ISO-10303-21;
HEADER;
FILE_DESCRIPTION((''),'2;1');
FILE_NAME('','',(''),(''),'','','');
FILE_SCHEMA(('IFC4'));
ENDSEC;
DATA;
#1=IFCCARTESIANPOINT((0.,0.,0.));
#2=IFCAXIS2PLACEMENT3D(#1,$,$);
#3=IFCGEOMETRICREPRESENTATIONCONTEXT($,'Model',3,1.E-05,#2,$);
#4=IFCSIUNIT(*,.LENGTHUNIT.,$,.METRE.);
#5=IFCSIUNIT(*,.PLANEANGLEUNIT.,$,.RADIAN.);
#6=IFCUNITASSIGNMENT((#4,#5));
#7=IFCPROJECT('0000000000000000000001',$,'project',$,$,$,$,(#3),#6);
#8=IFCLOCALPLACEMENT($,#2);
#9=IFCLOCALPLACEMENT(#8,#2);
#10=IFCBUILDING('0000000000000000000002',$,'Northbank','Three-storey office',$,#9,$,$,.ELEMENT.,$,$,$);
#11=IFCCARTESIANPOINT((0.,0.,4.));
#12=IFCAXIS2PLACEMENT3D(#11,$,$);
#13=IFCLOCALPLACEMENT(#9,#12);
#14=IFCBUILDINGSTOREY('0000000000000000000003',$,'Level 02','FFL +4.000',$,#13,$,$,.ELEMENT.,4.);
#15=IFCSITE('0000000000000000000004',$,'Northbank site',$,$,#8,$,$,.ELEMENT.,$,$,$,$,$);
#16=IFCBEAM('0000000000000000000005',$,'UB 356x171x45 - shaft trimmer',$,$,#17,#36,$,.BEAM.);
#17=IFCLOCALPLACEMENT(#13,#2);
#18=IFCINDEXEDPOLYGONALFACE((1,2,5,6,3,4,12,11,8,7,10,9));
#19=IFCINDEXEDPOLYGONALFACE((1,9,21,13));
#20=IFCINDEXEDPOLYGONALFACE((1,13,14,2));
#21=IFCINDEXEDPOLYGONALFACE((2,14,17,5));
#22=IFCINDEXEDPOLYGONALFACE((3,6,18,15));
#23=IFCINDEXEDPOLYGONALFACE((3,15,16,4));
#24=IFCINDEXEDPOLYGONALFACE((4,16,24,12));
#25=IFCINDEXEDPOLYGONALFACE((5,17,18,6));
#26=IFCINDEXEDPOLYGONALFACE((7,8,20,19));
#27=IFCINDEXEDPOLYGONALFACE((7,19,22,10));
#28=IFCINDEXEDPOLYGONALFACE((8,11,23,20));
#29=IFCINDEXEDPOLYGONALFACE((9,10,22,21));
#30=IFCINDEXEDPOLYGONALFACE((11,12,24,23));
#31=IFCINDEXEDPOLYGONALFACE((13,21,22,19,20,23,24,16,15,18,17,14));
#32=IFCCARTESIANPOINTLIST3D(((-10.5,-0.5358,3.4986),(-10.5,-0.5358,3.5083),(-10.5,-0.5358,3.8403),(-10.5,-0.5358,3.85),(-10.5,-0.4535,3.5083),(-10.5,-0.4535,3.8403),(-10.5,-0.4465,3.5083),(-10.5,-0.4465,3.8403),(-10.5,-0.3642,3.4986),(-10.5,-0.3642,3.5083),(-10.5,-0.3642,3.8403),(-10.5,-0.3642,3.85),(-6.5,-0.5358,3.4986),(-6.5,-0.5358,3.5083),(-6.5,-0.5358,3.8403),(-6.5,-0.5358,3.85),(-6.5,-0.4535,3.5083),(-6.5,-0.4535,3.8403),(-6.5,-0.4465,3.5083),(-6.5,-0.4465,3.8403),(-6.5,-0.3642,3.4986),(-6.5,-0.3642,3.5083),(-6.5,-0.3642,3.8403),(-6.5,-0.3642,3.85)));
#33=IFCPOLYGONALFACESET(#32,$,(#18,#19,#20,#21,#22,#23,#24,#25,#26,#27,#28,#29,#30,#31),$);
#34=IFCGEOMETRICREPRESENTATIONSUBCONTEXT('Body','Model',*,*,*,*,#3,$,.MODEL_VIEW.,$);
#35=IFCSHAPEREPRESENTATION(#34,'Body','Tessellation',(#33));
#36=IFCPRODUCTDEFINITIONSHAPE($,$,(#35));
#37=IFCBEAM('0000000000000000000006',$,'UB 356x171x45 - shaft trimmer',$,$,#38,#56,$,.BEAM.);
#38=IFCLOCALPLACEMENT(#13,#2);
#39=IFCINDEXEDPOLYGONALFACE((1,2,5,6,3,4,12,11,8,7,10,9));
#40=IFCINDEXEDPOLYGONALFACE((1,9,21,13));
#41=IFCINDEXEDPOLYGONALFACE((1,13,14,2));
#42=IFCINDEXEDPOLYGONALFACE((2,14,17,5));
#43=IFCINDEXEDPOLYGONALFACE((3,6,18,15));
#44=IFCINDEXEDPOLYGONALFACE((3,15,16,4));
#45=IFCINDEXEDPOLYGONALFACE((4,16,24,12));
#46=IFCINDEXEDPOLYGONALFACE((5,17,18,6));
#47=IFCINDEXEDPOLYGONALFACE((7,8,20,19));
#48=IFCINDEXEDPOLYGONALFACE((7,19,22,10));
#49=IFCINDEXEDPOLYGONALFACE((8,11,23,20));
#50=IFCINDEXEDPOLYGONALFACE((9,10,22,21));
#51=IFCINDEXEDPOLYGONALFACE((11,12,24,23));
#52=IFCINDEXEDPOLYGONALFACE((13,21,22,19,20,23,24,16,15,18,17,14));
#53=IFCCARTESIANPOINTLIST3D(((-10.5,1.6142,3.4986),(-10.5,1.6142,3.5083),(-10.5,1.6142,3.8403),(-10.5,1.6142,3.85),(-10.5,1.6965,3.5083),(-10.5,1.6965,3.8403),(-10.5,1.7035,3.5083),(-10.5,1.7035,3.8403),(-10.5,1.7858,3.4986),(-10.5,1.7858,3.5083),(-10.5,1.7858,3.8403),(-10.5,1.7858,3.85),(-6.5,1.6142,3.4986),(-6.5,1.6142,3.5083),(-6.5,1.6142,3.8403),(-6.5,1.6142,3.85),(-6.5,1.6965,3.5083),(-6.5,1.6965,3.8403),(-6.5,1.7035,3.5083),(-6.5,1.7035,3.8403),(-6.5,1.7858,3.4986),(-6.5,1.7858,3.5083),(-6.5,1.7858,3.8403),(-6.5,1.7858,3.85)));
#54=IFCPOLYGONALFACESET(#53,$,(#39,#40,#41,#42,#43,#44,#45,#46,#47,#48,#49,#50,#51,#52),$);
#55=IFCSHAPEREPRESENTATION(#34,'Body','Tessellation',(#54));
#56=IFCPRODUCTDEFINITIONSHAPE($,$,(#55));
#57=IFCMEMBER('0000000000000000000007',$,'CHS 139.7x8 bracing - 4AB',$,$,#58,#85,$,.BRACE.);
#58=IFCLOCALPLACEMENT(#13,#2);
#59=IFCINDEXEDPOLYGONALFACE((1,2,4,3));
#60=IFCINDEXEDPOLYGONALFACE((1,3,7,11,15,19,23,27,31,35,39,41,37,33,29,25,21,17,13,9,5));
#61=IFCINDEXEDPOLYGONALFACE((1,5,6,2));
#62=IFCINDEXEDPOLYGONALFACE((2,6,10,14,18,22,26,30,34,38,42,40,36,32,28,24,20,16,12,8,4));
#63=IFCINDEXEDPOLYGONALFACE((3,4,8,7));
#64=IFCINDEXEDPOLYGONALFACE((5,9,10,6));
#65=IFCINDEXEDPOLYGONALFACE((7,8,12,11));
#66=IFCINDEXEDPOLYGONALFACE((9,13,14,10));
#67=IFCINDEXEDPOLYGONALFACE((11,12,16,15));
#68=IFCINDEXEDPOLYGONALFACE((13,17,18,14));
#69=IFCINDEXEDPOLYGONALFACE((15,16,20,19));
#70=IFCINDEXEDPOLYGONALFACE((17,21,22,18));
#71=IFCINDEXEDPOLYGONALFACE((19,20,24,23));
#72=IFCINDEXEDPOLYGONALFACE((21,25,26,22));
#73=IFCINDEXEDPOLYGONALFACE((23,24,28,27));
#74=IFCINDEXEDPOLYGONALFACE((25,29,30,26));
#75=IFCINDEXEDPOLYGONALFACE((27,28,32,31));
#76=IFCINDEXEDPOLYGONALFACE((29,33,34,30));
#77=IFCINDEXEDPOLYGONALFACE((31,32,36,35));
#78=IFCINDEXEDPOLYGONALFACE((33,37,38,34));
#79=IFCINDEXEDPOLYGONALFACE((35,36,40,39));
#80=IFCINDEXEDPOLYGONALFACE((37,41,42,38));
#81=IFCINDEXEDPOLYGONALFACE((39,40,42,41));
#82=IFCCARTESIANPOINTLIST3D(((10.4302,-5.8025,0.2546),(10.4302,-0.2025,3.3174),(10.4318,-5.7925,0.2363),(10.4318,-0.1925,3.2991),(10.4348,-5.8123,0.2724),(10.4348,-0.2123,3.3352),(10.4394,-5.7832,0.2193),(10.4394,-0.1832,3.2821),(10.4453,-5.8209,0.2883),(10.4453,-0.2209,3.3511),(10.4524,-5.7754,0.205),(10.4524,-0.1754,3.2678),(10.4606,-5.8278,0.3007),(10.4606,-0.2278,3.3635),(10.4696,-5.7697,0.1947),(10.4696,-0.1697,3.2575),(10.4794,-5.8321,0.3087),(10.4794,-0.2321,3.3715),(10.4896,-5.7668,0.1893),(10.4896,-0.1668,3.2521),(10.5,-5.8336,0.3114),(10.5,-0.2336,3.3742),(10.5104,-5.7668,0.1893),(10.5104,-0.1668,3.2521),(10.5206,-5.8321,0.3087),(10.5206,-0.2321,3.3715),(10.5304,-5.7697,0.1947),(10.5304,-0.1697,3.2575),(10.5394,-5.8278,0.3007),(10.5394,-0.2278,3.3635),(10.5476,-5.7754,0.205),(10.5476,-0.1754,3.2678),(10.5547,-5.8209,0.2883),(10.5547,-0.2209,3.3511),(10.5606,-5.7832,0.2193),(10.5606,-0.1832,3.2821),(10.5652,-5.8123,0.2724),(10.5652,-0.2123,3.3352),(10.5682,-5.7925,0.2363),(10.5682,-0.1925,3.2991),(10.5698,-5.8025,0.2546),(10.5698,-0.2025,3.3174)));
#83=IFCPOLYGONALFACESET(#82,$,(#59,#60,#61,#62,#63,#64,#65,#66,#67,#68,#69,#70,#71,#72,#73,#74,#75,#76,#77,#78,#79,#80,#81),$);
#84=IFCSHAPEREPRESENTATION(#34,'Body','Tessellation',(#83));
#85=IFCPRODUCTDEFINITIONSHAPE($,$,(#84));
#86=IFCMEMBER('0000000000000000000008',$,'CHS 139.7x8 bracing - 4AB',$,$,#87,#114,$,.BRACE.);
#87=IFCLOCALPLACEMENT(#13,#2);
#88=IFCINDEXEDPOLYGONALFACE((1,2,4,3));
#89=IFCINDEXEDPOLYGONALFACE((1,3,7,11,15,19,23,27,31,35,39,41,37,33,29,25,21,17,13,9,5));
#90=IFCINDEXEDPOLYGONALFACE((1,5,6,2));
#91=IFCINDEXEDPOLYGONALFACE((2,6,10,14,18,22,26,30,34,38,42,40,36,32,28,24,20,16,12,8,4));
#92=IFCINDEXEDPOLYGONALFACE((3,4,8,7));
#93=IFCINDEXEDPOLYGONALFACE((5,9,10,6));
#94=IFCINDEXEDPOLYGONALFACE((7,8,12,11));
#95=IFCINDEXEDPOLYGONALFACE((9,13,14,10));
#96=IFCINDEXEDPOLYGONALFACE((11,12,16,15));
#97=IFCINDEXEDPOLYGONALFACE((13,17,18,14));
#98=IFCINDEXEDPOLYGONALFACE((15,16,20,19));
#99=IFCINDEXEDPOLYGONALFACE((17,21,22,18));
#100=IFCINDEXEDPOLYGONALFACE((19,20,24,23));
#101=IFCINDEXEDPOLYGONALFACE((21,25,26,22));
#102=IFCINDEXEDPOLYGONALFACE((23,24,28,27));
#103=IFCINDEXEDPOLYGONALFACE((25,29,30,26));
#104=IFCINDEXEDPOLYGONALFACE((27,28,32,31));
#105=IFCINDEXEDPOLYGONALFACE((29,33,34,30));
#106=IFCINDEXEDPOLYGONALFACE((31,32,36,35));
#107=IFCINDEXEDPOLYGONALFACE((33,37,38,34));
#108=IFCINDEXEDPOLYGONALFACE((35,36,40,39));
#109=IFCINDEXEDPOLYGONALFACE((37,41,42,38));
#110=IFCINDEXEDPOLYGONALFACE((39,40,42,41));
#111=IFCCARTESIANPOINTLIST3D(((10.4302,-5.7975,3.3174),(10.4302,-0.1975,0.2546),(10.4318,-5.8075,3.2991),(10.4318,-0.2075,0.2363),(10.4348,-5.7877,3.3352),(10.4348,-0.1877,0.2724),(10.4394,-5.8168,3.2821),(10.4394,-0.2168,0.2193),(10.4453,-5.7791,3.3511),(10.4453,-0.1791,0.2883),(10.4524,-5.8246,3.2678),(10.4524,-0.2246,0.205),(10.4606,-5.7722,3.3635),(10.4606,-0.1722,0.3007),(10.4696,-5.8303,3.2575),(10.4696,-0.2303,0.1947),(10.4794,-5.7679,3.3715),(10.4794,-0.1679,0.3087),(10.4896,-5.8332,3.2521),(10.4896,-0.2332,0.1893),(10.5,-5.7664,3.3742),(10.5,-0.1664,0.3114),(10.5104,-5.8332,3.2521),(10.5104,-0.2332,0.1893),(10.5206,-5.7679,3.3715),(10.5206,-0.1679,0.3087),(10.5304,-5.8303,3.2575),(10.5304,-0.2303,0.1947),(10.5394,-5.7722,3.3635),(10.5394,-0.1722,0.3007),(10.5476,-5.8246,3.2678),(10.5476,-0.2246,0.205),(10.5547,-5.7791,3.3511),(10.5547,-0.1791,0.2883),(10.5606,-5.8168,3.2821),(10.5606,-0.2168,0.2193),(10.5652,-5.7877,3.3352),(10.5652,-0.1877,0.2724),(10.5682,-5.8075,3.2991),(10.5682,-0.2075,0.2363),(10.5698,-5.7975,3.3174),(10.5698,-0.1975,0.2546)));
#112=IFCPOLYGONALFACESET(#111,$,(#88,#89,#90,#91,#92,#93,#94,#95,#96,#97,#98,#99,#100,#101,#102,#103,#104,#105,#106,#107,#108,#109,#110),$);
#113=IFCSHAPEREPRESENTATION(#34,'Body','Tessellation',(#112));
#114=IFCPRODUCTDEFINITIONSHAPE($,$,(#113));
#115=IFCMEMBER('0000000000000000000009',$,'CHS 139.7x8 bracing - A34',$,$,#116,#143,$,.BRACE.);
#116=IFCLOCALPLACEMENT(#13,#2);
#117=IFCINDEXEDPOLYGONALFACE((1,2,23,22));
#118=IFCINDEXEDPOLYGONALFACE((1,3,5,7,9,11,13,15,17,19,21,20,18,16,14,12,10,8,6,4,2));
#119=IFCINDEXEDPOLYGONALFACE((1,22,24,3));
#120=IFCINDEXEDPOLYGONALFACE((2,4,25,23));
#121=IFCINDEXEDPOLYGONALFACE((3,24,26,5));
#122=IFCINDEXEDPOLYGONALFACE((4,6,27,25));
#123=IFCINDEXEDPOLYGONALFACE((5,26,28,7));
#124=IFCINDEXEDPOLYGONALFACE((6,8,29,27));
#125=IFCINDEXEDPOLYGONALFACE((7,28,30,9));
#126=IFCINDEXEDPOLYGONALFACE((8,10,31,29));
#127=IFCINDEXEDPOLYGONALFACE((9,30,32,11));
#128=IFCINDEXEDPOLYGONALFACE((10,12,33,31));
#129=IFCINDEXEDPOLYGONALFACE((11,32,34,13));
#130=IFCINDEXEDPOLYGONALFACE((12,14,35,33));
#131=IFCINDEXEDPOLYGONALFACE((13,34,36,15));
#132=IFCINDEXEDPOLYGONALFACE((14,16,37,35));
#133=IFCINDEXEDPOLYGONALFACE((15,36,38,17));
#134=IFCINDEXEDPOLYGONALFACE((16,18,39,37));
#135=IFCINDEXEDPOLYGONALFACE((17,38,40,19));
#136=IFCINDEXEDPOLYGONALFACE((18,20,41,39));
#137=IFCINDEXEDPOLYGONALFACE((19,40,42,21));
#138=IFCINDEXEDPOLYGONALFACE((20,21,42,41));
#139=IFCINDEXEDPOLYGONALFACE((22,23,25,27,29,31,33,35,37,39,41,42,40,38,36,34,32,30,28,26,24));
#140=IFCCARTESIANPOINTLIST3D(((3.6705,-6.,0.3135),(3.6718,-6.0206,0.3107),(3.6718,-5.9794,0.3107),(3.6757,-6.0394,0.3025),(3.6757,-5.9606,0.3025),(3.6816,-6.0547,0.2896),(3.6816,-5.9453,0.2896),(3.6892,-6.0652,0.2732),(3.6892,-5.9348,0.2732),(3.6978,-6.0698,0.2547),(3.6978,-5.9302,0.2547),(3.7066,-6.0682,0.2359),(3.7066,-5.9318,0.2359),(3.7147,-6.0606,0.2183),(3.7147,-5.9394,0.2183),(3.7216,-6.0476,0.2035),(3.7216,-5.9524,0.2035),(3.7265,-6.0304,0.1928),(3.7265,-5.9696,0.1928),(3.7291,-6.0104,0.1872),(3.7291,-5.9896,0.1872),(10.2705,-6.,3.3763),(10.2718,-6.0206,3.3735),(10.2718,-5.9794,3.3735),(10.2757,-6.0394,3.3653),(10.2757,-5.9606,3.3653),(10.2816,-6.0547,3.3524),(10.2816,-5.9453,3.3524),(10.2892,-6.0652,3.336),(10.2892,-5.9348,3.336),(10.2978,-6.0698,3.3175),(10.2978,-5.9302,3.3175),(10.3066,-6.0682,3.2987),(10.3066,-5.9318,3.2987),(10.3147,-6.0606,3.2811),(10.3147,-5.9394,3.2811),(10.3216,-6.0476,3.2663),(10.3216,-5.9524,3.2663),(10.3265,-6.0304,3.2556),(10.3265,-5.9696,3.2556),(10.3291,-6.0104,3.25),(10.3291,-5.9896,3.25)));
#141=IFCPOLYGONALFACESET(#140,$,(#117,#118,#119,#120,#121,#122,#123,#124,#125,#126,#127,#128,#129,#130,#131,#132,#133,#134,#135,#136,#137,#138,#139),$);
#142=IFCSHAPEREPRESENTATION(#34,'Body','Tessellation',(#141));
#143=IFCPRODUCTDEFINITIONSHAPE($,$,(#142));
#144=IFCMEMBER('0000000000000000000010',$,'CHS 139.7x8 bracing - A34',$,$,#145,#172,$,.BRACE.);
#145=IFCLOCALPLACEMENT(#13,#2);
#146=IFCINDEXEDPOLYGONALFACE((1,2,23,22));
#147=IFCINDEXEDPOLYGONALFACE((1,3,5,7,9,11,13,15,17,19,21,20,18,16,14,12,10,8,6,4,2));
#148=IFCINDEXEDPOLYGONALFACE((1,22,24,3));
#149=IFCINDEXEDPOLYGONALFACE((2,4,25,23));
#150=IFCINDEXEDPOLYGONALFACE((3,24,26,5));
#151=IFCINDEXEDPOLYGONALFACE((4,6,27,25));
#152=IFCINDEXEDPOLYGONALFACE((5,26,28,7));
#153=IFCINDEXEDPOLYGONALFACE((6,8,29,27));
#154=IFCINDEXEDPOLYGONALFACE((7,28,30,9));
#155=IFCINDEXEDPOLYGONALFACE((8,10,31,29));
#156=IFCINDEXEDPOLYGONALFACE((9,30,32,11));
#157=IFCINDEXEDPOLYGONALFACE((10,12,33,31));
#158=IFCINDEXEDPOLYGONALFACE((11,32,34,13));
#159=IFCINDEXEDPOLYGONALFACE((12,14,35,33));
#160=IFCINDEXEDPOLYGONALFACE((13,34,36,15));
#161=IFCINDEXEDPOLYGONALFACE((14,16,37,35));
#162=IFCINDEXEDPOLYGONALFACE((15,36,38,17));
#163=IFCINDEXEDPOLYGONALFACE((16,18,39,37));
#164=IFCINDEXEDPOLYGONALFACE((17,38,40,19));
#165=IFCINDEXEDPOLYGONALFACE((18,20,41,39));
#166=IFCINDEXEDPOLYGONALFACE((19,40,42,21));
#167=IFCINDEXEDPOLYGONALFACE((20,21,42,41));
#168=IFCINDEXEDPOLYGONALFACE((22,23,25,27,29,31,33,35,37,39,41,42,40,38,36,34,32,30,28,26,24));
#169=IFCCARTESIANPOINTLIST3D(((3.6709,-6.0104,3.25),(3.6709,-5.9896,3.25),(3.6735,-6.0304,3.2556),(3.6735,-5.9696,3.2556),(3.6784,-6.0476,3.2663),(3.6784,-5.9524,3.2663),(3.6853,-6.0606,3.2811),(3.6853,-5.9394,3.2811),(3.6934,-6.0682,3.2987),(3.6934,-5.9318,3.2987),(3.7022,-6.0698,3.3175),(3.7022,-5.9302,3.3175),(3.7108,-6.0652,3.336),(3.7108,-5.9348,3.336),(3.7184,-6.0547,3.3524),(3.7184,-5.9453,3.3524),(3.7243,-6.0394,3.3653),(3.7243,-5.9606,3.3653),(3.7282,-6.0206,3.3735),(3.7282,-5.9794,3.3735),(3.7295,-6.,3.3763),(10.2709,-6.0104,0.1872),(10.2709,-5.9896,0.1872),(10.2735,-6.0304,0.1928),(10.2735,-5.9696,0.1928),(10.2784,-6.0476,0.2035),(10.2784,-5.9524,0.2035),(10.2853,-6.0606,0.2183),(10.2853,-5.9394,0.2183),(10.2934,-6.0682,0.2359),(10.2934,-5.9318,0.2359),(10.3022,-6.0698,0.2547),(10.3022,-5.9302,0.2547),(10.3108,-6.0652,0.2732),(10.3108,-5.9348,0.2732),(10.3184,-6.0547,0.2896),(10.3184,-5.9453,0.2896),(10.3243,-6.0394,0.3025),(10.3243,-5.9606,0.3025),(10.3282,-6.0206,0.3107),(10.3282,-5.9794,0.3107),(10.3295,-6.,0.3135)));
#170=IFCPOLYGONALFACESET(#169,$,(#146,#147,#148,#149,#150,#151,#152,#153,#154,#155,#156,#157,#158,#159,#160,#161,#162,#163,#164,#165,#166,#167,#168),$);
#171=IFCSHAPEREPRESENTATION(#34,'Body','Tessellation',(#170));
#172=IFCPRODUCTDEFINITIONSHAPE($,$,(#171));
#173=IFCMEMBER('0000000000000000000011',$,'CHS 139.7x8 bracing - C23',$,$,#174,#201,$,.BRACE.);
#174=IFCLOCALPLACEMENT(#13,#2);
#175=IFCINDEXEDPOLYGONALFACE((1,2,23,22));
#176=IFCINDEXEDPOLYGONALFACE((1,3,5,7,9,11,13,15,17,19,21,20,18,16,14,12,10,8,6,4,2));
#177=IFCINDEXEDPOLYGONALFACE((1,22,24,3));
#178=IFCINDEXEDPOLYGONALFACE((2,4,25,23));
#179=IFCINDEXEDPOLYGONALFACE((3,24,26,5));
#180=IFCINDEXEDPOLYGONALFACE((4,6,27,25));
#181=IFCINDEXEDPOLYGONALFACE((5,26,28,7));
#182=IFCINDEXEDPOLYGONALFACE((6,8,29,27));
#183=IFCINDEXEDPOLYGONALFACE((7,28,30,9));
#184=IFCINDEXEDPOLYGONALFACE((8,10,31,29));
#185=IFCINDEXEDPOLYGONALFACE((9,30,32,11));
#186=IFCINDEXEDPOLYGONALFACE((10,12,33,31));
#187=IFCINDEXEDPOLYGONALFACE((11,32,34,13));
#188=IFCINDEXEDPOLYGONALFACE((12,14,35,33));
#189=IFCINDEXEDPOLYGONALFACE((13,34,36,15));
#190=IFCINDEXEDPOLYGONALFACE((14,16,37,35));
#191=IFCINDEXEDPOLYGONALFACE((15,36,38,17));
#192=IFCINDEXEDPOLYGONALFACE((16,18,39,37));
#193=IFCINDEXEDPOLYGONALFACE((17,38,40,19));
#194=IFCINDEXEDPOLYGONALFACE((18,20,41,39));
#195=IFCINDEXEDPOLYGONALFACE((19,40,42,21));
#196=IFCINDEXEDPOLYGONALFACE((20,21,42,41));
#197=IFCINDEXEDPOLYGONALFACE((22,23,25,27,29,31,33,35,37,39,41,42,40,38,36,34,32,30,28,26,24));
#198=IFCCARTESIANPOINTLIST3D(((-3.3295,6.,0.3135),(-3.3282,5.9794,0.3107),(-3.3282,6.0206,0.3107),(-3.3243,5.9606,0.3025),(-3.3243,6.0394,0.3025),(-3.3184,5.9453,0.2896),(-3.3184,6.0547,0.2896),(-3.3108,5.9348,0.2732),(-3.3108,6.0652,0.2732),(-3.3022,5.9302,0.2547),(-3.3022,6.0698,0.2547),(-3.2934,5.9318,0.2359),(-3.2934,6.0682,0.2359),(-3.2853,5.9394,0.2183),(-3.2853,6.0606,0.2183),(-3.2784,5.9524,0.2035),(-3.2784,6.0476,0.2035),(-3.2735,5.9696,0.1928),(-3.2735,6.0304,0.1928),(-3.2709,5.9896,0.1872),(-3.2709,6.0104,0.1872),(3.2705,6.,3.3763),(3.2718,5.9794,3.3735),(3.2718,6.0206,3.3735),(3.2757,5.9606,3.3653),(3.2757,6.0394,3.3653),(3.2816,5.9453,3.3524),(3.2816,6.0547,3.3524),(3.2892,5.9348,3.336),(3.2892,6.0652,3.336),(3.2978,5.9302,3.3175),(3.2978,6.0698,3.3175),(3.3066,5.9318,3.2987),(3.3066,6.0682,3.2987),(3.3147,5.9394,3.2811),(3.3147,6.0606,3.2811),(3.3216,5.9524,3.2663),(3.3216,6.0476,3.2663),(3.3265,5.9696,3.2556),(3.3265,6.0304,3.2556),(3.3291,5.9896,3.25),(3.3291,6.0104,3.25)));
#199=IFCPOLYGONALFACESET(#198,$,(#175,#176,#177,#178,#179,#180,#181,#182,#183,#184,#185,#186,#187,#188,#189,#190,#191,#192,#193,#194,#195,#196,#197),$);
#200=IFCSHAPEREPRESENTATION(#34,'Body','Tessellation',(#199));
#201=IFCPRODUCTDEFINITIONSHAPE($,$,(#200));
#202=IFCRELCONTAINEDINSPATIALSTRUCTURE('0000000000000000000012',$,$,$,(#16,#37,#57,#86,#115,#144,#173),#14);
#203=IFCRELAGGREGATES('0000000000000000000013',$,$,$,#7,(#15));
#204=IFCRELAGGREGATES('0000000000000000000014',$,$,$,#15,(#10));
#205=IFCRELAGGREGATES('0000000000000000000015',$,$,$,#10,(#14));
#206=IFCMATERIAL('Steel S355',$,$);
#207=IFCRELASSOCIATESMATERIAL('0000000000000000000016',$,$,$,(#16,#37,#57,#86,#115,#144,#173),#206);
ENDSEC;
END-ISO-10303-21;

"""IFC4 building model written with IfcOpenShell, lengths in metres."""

from ifc_helpers import new_model, si_unit, frame, origin, place, context, subcontext, project, spatial, circle, i_section, extrude, material, element, save


model = new_model("IFC4")

# Units and contexts
model_context = context("Model", 3, precision=1e-05, world=origin())
body_context = subcontext(model_context, "Body", "Model", "MODEL_VIEW")
ifc_project = project(units=[si_unit("LENGTHUNIT", "METRE"), si_unit("PLANEANGLEUNIT", "RADIAN")], contexts=[model_context])

# Site, building, storey
site_placement = place(None, origin())
site = spatial("IfcSite", under=ifc_project, at=site_placement, Name="Northbank site", CompositionType="ELEMENT")
building_placement = place(site_placement, origin())
building = spatial("IfcBuilding", under=site, at=building_placement, Name="Northbank", Description="Three-storey office", CompositionType="ELEMENT")
storey_placement = place(building_placement, frame((0.0, 0.0, 4.0)))
storey = spatial("IfcBuildingStorey", under=building, at=storey_placement, Name="Level 02", Description="FFL +4.000", CompositionType="ELEMENT", Elevation=4.0)

# Beams
ifc_material_1 = material(Name="Steel S355")
beam_1_placement = place(storey_placement, frame((0.0, 0.0, -4.0)))
element("IfcBeam", 1, at=beam_1_placement, inside=storey, material=ifc_material_1, Name="UB 356x171x45 - shaft trimmer", PredefinedType="BEAM", context=body_context, shape_type="SweptSolid", body=[
    extrude(i_section(OverallWidth=0.1715, OverallDepth=0.3514, WebThickness=0.007, FlangeThickness=0.0097), frame((-10.5, -0.45, 7.6743), z_axis=(1.0, 0.0, 0.0), x_axis=(0.0, 1.0, 0.0)), (0.0, 0.0, 1.0), 4.0),
])
beam_2_placement = place(storey_placement, frame((0.0, 0.0, -4.0)))
element("IfcBeam", 2, at=beam_2_placement, inside=storey, material=ifc_material_1, Name="UB 356x171x45 - shaft trimmer", PredefinedType="BEAM", context=body_context, shape_type="SweptSolid", body=[
    extrude(i_section(OverallWidth=0.1715, OverallDepth=0.3514, WebThickness=0.007, FlangeThickness=0.0097), frame((-10.5, 1.7, 7.6743), z_axis=(1.0, 0.0, 0.0), x_axis=(0.0, 1.0, 0.0)), (0.0, 0.0, 1.0), 4.0),
])

# Members
member_1_placement = place(storey_placement, frame((0.0, 0.0, -4.0)))
element("IfcMember", 3, at=member_1_placement, inside=storey, material=ifc_material_1, Name="CHS 139.7x8 bracing - 4AB", PredefinedType="BRACE", context=body_context, shape_type="SweptSolid", body=[
    extrude(circle(Radius=0.07), frame((10.5, -5.8, 4.25), z_axis=(0.0, 0.877351, 0.479849), x_axis=(0.0, -0.479849, 0.877351)), (0.0, 0.0, 1.0), 6.3828),
])
member_2_placement = place(storey_placement, frame((0.0, 0.0, -4.0)))
element("IfcMember", 4, at=member_2_placement, inside=storey, material=ifc_material_1, Name="CHS 139.7x8 bracing - 4AB", PredefinedType="BRACE", context=body_context, shape_type="SweptSolid", body=[
    extrude(circle(Radius=0.07), frame((10.5, -0.2, 4.25), z_axis=(0.0, -0.877351, 0.479849), x_axis=(0.0, 0.479849, 0.877351)), (0.0, 0.0, 1.0), 6.3828),
])
member_3_placement = place(storey_placement, frame((0.0, 0.0, -4.0)))
element("IfcMember", 5, at=member_3_placement, inside=storey, material=ifc_material_1, Name="CHS 139.7x8 bracing - A34", PredefinedType="BRACE", context=body_context, shape_type="SweptSolid", body=[
    extrude(circle(Radius=0.07), frame((3.7, -6.0, 4.25), z_axis=(0.907087, 0.0, 0.420943), x_axis=(-0.420943, 0.0, 0.907087)), (0.0, 0.0, 1.0), 7.276),
])
member_4_placement = place(storey_placement, frame((0.0, 0.0, -4.0)))
element("IfcMember", 6, at=member_4_placement, inside=storey, material=ifc_material_1, Name="CHS 139.7x8 bracing - A34", PredefinedType="BRACE", context=body_context, shape_type="SweptSolid", body=[
    extrude(circle(Radius=0.07), frame((10.3, -6.0, 4.25), z_axis=(-0.907087, 0.0, 0.420943), x_axis=(0.420943, 0.0, 0.907087)), (0.0, 0.0, 1.0), 7.276),
])
member_5_placement = place(storey_placement, frame((0.0, 0.0, -4.0)))
element("IfcMember", 7, at=member_5_placement, inside=storey, material=ifc_material_1, Name="CHS 139.7x8 bracing - C23", PredefinedType="BRACE", context=body_context, shape_type="SweptSolid", body=[
    extrude(circle(Radius=0.07), frame((-3.3, 6.0, 4.25), z_axis=(0.907087, 0.0, 0.420943), x_axis=(-0.420943, 0.0, 0.907087)), (0.0, 0.0, 1.0), 7.276),
])

save(model, "model.ifc")
